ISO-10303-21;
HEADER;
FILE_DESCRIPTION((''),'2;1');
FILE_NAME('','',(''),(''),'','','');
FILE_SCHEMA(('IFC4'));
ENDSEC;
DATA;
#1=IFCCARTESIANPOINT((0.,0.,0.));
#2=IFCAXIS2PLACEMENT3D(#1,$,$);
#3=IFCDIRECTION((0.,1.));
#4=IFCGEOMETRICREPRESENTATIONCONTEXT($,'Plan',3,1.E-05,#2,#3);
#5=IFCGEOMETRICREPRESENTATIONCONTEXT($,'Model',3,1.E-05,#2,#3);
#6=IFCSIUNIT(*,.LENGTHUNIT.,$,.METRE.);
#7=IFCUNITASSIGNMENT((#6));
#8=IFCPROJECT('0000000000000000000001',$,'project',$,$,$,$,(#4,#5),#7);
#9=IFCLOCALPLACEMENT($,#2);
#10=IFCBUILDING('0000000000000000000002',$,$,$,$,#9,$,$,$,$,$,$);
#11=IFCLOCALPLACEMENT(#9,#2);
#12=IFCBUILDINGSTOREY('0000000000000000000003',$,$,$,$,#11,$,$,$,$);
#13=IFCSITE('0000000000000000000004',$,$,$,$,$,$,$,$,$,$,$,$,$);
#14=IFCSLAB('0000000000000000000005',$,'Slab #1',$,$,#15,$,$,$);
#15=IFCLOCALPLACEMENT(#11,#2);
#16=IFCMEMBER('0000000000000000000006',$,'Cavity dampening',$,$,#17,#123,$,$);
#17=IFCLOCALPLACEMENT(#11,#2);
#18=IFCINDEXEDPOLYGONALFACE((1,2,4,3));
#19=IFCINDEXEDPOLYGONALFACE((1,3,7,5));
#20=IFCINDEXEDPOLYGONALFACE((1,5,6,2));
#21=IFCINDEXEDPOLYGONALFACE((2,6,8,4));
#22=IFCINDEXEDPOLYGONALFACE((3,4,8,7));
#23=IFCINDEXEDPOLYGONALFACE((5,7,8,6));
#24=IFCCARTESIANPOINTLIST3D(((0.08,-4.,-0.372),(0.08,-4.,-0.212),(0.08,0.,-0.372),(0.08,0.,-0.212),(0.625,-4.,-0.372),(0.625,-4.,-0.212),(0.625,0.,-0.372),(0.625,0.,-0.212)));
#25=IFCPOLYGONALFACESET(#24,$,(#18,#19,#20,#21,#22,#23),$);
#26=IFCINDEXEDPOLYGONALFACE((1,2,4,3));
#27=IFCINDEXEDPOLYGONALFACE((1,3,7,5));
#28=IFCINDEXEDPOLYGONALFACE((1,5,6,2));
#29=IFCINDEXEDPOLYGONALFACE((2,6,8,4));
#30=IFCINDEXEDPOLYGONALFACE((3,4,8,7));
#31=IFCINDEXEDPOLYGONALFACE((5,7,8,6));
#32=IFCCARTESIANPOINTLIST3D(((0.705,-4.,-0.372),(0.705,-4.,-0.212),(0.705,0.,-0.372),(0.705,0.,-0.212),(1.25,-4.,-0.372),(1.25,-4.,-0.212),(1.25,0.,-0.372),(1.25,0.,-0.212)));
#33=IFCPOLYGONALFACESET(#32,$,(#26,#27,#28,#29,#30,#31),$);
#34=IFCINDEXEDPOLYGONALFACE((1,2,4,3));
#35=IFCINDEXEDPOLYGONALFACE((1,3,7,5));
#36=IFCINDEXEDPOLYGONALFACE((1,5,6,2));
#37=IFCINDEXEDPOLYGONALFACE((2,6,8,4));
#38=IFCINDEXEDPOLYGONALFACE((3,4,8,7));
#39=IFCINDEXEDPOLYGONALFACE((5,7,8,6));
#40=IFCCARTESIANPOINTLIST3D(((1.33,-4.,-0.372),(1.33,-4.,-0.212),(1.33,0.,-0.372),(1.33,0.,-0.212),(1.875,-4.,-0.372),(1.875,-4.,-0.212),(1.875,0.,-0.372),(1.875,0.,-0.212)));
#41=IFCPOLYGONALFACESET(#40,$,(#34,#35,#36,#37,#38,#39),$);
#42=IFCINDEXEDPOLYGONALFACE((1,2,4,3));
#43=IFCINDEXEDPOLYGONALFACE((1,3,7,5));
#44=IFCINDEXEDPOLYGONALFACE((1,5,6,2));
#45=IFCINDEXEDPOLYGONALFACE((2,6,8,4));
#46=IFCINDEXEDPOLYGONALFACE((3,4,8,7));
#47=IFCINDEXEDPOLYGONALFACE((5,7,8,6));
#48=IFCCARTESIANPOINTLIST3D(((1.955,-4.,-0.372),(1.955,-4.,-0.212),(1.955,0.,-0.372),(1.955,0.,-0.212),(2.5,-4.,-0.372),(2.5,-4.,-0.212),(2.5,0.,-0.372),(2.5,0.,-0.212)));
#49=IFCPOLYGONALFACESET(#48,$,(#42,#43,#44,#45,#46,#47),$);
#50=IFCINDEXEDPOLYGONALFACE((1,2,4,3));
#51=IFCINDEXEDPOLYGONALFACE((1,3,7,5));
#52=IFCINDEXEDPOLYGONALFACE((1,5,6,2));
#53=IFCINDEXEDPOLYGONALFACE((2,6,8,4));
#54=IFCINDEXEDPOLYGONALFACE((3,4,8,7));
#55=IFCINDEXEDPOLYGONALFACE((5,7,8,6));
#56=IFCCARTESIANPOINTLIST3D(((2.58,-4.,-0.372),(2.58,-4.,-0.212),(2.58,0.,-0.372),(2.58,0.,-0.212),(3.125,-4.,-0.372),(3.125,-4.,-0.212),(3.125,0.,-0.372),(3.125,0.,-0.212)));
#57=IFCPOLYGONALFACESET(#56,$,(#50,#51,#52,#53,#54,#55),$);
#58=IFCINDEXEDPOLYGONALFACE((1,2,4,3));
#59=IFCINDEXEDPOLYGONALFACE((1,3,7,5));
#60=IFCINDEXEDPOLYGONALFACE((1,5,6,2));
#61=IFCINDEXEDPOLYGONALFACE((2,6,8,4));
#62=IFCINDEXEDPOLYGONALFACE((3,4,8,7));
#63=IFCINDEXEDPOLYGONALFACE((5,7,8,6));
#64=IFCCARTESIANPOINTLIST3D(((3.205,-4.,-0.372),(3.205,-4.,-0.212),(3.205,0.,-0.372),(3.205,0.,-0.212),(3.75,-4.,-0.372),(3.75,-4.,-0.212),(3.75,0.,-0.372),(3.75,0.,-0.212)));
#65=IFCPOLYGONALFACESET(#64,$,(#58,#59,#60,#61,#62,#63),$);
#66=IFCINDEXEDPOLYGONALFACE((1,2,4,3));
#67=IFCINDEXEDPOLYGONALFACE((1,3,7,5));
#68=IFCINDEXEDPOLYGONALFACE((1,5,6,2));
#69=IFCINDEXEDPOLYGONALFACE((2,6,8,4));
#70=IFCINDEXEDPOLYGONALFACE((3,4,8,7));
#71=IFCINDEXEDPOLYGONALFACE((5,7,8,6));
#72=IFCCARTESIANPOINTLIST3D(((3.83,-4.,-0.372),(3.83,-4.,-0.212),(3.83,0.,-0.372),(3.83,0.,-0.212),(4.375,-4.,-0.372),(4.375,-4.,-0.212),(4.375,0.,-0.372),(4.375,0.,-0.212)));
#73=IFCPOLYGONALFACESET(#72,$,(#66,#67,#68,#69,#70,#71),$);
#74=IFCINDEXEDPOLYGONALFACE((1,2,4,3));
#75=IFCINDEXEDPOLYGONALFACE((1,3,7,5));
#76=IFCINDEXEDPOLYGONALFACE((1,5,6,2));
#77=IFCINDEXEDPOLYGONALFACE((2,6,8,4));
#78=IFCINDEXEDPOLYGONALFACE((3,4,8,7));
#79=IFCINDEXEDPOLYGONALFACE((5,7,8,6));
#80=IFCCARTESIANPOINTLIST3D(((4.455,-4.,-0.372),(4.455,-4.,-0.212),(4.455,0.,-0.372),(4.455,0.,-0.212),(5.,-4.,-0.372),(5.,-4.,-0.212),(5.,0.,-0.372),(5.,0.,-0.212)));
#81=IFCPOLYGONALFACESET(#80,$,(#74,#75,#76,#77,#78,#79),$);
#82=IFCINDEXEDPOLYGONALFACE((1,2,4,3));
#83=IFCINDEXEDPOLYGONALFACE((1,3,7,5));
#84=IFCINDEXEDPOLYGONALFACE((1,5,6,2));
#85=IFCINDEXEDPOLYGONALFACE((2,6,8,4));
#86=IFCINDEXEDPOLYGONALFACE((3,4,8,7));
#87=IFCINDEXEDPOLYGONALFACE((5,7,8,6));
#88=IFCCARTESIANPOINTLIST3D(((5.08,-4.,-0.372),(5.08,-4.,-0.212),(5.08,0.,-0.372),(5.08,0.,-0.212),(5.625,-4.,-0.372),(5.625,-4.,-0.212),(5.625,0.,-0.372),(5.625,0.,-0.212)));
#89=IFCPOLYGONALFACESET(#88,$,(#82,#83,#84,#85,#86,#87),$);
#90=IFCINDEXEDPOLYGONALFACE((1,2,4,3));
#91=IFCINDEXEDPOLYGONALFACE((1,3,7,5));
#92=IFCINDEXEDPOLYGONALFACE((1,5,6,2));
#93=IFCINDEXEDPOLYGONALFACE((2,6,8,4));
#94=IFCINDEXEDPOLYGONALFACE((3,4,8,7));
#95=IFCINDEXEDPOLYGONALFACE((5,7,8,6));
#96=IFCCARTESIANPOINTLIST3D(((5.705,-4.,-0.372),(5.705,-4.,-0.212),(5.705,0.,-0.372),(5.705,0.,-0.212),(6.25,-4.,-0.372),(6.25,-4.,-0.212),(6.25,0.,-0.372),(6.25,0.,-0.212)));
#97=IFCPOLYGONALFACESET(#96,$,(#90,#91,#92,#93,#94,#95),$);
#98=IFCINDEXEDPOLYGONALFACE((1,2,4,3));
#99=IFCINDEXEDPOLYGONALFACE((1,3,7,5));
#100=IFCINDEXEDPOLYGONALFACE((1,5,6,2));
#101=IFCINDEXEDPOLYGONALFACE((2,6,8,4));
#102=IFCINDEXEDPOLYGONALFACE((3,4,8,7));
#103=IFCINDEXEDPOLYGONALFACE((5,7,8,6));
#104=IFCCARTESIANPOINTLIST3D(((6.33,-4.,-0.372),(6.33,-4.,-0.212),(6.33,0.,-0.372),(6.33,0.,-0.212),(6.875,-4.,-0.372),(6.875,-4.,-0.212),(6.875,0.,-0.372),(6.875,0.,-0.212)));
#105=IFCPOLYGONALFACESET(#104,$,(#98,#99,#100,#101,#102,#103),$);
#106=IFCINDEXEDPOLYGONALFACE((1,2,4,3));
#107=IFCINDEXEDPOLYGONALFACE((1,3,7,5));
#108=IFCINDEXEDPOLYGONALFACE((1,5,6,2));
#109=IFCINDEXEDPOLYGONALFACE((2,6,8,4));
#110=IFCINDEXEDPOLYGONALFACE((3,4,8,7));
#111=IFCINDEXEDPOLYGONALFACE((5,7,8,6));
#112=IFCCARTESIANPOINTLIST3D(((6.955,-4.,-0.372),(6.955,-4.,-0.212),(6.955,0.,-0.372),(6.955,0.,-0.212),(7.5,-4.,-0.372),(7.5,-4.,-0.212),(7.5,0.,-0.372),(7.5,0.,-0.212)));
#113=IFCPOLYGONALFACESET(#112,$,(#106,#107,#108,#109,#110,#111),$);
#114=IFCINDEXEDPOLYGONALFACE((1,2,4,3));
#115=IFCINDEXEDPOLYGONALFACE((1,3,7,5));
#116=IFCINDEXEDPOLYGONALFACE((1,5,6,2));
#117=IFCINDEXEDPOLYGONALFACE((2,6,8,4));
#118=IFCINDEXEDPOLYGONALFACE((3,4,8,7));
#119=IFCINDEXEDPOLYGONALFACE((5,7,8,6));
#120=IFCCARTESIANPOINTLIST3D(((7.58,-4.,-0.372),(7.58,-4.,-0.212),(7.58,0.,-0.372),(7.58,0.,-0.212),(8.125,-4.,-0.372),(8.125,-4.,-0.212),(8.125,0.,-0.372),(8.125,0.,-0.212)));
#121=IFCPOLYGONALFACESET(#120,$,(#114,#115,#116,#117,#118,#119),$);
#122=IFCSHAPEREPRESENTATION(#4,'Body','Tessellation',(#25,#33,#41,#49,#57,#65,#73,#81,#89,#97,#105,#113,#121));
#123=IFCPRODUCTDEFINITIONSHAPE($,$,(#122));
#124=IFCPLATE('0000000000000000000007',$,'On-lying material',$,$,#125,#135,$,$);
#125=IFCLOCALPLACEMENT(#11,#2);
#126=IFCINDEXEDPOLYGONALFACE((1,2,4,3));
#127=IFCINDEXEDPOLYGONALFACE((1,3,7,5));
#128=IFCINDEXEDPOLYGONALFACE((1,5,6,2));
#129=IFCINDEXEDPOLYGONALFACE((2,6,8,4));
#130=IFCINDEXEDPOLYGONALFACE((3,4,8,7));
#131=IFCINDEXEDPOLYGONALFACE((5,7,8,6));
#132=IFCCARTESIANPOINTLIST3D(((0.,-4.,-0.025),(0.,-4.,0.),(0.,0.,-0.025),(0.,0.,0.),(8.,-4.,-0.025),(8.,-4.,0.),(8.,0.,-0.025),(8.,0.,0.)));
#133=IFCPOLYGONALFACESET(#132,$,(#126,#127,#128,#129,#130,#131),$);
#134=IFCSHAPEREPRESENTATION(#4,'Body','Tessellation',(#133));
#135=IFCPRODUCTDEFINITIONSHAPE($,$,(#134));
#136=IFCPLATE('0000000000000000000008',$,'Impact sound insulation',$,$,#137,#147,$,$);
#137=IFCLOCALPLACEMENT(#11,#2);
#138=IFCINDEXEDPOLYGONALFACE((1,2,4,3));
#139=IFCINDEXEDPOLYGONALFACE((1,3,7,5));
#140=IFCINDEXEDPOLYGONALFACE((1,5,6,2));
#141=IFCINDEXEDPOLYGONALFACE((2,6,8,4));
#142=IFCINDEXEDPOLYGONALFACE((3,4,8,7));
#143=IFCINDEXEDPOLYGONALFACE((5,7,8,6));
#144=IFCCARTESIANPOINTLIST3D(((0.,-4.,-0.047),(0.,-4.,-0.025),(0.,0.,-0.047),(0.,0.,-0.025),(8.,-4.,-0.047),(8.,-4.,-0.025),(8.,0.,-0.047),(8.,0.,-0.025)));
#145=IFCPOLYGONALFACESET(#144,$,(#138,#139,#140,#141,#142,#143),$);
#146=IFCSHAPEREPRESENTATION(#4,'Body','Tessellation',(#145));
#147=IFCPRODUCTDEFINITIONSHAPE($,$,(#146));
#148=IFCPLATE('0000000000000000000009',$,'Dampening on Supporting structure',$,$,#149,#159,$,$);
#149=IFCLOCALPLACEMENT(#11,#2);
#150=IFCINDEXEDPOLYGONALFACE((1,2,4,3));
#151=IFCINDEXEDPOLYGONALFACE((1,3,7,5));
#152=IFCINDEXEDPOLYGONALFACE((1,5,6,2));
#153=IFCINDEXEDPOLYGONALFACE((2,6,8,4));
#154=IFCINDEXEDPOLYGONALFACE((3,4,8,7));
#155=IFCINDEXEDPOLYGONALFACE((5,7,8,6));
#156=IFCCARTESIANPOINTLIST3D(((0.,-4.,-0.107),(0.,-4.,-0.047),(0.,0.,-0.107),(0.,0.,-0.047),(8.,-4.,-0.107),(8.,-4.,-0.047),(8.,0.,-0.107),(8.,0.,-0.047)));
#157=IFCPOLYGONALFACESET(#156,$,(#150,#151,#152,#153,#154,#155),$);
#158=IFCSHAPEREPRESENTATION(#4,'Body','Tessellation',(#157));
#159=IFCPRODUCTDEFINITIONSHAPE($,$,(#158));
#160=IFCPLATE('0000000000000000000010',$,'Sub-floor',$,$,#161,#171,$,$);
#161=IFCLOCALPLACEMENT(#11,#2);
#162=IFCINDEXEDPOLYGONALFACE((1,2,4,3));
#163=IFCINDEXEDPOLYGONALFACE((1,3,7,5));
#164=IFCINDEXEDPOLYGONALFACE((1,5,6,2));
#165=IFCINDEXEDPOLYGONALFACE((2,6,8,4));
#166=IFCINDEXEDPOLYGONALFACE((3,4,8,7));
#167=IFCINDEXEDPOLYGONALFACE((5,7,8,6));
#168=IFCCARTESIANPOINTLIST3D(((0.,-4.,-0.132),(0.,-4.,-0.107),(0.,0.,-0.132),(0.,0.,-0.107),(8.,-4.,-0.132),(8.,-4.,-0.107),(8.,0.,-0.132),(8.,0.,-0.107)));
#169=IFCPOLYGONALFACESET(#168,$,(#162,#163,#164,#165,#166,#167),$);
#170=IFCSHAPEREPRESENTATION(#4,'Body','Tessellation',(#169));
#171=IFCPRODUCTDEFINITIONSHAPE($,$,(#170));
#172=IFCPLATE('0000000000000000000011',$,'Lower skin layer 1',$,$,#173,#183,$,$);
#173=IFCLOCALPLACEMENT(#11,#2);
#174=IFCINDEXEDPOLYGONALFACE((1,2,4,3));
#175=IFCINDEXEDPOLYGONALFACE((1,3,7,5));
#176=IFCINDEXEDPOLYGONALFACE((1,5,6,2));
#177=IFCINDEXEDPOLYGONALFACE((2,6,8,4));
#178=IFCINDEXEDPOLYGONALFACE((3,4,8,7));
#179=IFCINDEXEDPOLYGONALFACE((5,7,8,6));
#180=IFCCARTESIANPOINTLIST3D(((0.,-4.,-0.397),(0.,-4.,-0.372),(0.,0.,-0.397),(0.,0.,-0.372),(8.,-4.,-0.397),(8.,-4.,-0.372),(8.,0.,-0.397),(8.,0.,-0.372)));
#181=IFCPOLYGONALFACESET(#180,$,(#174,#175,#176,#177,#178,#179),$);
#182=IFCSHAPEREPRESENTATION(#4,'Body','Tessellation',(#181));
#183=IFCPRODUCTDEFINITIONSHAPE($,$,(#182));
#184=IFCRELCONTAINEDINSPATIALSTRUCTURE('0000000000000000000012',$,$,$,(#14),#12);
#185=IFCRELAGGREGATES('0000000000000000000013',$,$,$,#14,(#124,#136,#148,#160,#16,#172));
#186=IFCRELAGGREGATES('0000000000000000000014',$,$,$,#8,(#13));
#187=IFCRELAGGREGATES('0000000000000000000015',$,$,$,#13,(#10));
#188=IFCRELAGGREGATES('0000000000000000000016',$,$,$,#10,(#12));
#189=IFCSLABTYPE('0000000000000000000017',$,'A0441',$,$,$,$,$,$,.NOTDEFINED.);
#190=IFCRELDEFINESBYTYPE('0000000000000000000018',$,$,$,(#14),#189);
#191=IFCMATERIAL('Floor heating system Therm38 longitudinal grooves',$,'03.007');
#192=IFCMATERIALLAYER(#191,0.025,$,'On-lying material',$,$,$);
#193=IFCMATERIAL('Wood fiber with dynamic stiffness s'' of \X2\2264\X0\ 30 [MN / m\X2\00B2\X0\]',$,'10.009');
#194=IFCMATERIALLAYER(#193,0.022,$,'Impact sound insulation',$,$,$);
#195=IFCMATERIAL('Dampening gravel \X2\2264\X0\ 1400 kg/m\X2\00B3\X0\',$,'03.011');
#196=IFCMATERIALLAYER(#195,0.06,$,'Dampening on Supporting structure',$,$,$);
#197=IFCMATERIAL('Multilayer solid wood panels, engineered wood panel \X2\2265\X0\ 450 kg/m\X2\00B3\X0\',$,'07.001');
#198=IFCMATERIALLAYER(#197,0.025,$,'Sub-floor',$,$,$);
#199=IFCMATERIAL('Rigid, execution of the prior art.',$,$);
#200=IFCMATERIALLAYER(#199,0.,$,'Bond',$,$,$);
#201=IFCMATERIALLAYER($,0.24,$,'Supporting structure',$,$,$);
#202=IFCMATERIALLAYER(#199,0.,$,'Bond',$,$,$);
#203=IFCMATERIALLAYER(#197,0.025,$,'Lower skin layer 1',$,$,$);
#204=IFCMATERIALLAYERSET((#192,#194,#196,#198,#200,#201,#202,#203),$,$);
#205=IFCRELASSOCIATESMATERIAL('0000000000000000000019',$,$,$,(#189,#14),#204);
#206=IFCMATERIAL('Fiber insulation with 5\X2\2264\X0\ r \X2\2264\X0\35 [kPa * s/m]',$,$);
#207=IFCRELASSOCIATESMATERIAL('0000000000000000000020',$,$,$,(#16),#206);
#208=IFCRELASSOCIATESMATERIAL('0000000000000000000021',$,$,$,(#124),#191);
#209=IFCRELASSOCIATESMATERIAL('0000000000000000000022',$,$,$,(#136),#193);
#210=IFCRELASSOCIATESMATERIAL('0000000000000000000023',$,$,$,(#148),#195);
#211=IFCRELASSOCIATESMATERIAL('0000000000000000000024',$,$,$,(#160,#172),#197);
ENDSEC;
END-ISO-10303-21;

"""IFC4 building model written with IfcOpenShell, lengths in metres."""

from ifc_helpers import new_model, si_unit, direction, frame, frame_2d, origin, origin_with_axes, place, context, project, spatial, rectangle, extrude, material, layer, layer_set, type_object, element, aggregate, save


model = new_model("IFC4")

# Units and contexts
plan_context = context("Plan", 3, precision=1e-05, world=origin(), true_north=direction((0.0, 1.0)))
model_context = context("Model", 3, precision=1e-05, world=origin(), true_north=direction((0.0, 1.0)))
ifc_project = project(units=[si_unit("LENGTHUNIT", "METRE")], contexts=[plan_context, model_context])

# Site, building, storey
site = spatial("IfcSite", under=ifc_project)
building_placement = place(None, origin())
building = spatial("IfcBuilding", under=site, at=building_placement)
storey_placement = place(building_placement, origin())
storey = spatial("IfcBuildingStorey", under=building, at=storey_placement)

# Slab, member, plates
ifc_material_1 = material(Name="Floor heating system Therm38 longitudinal grooves", Category="03.007")
ifc_layer_1 = layer(ifc_material_1, 0.025, Name="On-lying material")
ifc_material_2 = material(Name="Wood fiber with dynamic stiffness s' of ≤ 30 [MN / m²]", Category="10.009")
ifc_layer_2 = layer(ifc_material_2, 0.022, Name="Impact sound insulation")
ifc_material_3 = material(Name="Dampening gravel ≤ 1400 kg/m³", Category="03.011")
ifc_layer_3 = layer(ifc_material_3, 0.06, Name="Dampening on Supporting structure")
ifc_material_4 = material(Name="Multilayer solid wood panels, engineered wood panel ≥ 450 kg/m³", Category="07.001")
ifc_layer_4 = layer(ifc_material_4, 0.025, Name="Sub-floor")
ifc_material_5 = material(Name="Rigid, execution of the prior art.")
ifc_layer_5 = layer(ifc_material_5, 0.0, Name="Bond")
ifc_layer_6 = layer(None, 0.24, Name="Supporting structure")
ifc_layer_7 = layer(ifc_material_5, 0.0, Name="Bond")
ifc_layer_8 = layer(ifc_material_4, 0.025, Name="Lower skin layer 1")
ifc_layer_set = layer_set([ifc_layer_1, ifc_layer_2, ifc_layer_3, ifc_layer_4, ifc_layer_5, ifc_layer_6, ifc_layer_7, ifc_layer_8])
slab_type = type_object("IfcSlabType", Name="A0441", PredefinedType="NOTDEFINED", material=ifc_layer_set)
slab_placement = place(None, frame((0.0, 0.0, 0.0), z_axis=(0.0, 0.0, -1.0), x_axis=(1.0, 0.0, 0.0)))
slab = element("IfcSlab", 1, at=slab_placement, inside=storey, type_object=slab_type, material=ifc_layer_set, Name="Slab #1")
ifc_material_6 = material(Name="Fiber insulation with 5≤ r ≤35 [kPa * s/m]")
member_1_placement = place(slab_placement, origin())
member_1 = element("IfcMember", 2, at=member_1_placement, material=ifc_material_6, Name="Cavity dampening", context=plan_context, shape_type="SweptSolid", body=[
    extrude(rectangle(XDim=0.545, YDim=0.16, at=frame_2d((0.2725, 0.08), x_axis=(1.0, 0.0))), frame((0.08, 4.0, 0.212), z_axis=(0.0, -1.0, 0.0), x_axis=(1.0, 0.0, 0.0)), (0.0, 0.0, 1.0), 4.0),
    extrude(rectangle(XDim=0.545, YDim=0.16, at=frame_2d((0.2725, 0.08), x_axis=(1.0, 0.0))), frame((0.705, 4.0, 0.212), z_axis=(0.0, -1.0, 0.0), x_axis=(1.0, 0.0, 0.0)), (0.0, 0.0, 1.0), 4.0),
    extrude(rectangle(XDim=0.545, YDim=0.16, at=frame_2d((0.2725, 0.08), x_axis=(1.0, 0.0))), frame((1.33, 4.0, 0.212), z_axis=(0.0, -1.0, 0.0), x_axis=(1.0, 0.0, 0.0)), (0.0, 0.0, 1.0), 4.0),
    extrude(rectangle(XDim=0.545, YDim=0.16, at=frame_2d((0.2725, 0.08), x_axis=(1.0, 0.0))), frame((1.955, 4.0, 0.212), z_axis=(0.0, -1.0, 0.0), x_axis=(1.0, 0.0, 0.0)), (0.0, 0.0, 1.0), 4.0),
    extrude(rectangle(XDim=0.545, YDim=0.16, at=frame_2d((0.2725, 0.08), x_axis=(1.0, 0.0))), frame((2.58, 4.0, 0.212), z_axis=(0.0, -1.0, 0.0), x_axis=(1.0, 0.0, 0.0)), (0.0, 0.0, 1.0), 4.0),
    extrude(rectangle(XDim=0.545, YDim=0.16, at=frame_2d((0.2725, 0.08), x_axis=(1.0, 0.0))), frame((3.205, 4.0, 0.212), z_axis=(0.0, -1.0, 0.0), x_axis=(1.0, 0.0, 0.0)), (0.0, 0.0, 1.0), 4.0),
    extrude(rectangle(XDim=0.545, YDim=0.16, at=frame_2d((0.2725, 0.08), x_axis=(1.0, 0.0))), frame((3.83, 4.0, 0.212), z_axis=(0.0, -1.0, 0.0), x_axis=(1.0, 0.0, 0.0)), (0.0, 0.0, 1.0), 4.0),
    extrude(rectangle(XDim=0.545, YDim=0.16, at=frame_2d((0.2725, 0.08), x_axis=(1.0, 0.0))), frame((4.455, 4.0, 0.212), z_axis=(0.0, -1.0, 0.0), x_axis=(1.0, 0.0, 0.0)), (0.0, 0.0, 1.0), 4.0),
    extrude(rectangle(XDim=0.545, YDim=0.16, at=frame_2d((0.2725, 0.08), x_axis=(1.0, 0.0))), frame((5.08, 4.0, 0.212), z_axis=(0.0, -1.0, 0.0), x_axis=(1.0, 0.0, 0.0)), (0.0, 0.0, 1.0), 4.0),
    extrude(rectangle(XDim=0.545, YDim=0.16, at=frame_2d((0.2725, 0.08), x_axis=(1.0, 0.0))), frame((5.705, 4.0, 0.212), z_axis=(0.0, -1.0, 0.0), x_axis=(1.0, 0.0, 0.0)), (0.0, 0.0, 1.0), 4.0),
    extrude(rectangle(XDim=0.545, YDim=0.16, at=frame_2d((0.2725, 0.08), x_axis=(1.0, 0.0))), frame((6.33, 4.0, 0.212), z_axis=(0.0, -1.0, 0.0), x_axis=(1.0, 0.0, 0.0)), (0.0, 0.0, 1.0), 4.0),
    extrude(rectangle(XDim=0.545, YDim=0.16, at=frame_2d((0.2725, 0.08), x_axis=(1.0, 0.0))), frame((6.955, 4.0, 0.212), z_axis=(0.0, -1.0, 0.0), x_axis=(1.0, 0.0, 0.0)), (0.0, 0.0, 1.0), 4.0),
    extrude(rectangle(XDim=0.545, YDim=0.16, at=frame_2d((0.2725, 0.08), x_axis=(1.0, 0.0))), frame((7.58, 4.0, 0.212), z_axis=(0.0, -1.0, 0.0), x_axis=(1.0, 0.0, 0.0)), (0.0, 0.0, 1.0), 4.0),
])
plate_1_placement = place(slab_placement, origin())
plate_1 = element("IfcPlate", 3, at=plate_1_placement, material=ifc_material_1, Name="On-lying material", context=plan_context, shape_type="SweptSolid", body=[
    extrude(rectangle(XDim=8.0, YDim=4.0, at=frame_2d((4.0, 2.0), x_axis=(1.0, 0.0))), origin_with_axes(), (0.0, 0.0, 1.0), 0.025),
])
plate_2_placement = place(slab_placement, origin())
plate_2 = element("IfcPlate", 4, at=plate_2_placement, material=ifc_material_2, Name="Impact sound insulation", context=plan_context, shape_type="SweptSolid", body=[
    extrude(rectangle(XDim=8.0, YDim=4.0, at=frame_2d((4.0, 2.0), x_axis=(1.0, 0.0))), frame((0.0, 0.0, 0.025), z_axis=(0.0, 0.0, 1.0), x_axis=(1.0, 0.0, 0.0)), (0.0, 0.0, 1.0), 0.022),
])
plate_3_placement = place(slab_placement, origin())
plate_3 = element("IfcPlate", 5, at=plate_3_placement, material=ifc_material_3, Name="Dampening on Supporting structure", context=plan_context, shape_type="SweptSolid", body=[
    extrude(rectangle(XDim=8.0, YDim=4.0, at=frame_2d((4.0, 2.0), x_axis=(1.0, 0.0))), frame((0.0, 0.0, 0.047), z_axis=(0.0, 0.0, 1.0), x_axis=(1.0, 0.0, 0.0)), (0.0, 0.0, 1.0), 0.06),
])
plate_4_placement = place(slab_placement, origin())
plate_4 = element("IfcPlate", 6, at=plate_4_placement, material=ifc_material_4, Name="Sub-floor", context=plan_context, shape_type="SweptSolid", body=[
    extrude(rectangle(XDim=8.0, YDim=4.0, at=frame_2d((4.0, 2.0), x_axis=(1.0, 0.0))), frame((0.0, 0.0, 0.107), z_axis=(0.0, 0.0, 1.0), x_axis=(1.0, 0.0, 0.0)), (0.0, 0.0, 1.0), 0.025),
])
plate_5_placement = place(slab_placement, origin())
plate_5 = element("IfcPlate", 7, at=plate_5_placement, material=ifc_material_4, Name="Lower skin layer 1", context=plan_context, shape_type="SweptSolid", body=[
    extrude(rectangle(XDim=8.0, YDim=4.0, at=frame_2d((4.0, 2.0), x_axis=(1.0, 0.0))), frame((0.0, 0.0, 0.372), z_axis=(0.0, 0.0, 1.0), x_axis=(1.0, 0.0, 0.0)), (0.0, 0.0, 1.0), 0.025),
])
aggregate(slab, [plate_1, plate_2, plate_3, plate_4, member_1, plate_5])

save(model, "model.ifc")
